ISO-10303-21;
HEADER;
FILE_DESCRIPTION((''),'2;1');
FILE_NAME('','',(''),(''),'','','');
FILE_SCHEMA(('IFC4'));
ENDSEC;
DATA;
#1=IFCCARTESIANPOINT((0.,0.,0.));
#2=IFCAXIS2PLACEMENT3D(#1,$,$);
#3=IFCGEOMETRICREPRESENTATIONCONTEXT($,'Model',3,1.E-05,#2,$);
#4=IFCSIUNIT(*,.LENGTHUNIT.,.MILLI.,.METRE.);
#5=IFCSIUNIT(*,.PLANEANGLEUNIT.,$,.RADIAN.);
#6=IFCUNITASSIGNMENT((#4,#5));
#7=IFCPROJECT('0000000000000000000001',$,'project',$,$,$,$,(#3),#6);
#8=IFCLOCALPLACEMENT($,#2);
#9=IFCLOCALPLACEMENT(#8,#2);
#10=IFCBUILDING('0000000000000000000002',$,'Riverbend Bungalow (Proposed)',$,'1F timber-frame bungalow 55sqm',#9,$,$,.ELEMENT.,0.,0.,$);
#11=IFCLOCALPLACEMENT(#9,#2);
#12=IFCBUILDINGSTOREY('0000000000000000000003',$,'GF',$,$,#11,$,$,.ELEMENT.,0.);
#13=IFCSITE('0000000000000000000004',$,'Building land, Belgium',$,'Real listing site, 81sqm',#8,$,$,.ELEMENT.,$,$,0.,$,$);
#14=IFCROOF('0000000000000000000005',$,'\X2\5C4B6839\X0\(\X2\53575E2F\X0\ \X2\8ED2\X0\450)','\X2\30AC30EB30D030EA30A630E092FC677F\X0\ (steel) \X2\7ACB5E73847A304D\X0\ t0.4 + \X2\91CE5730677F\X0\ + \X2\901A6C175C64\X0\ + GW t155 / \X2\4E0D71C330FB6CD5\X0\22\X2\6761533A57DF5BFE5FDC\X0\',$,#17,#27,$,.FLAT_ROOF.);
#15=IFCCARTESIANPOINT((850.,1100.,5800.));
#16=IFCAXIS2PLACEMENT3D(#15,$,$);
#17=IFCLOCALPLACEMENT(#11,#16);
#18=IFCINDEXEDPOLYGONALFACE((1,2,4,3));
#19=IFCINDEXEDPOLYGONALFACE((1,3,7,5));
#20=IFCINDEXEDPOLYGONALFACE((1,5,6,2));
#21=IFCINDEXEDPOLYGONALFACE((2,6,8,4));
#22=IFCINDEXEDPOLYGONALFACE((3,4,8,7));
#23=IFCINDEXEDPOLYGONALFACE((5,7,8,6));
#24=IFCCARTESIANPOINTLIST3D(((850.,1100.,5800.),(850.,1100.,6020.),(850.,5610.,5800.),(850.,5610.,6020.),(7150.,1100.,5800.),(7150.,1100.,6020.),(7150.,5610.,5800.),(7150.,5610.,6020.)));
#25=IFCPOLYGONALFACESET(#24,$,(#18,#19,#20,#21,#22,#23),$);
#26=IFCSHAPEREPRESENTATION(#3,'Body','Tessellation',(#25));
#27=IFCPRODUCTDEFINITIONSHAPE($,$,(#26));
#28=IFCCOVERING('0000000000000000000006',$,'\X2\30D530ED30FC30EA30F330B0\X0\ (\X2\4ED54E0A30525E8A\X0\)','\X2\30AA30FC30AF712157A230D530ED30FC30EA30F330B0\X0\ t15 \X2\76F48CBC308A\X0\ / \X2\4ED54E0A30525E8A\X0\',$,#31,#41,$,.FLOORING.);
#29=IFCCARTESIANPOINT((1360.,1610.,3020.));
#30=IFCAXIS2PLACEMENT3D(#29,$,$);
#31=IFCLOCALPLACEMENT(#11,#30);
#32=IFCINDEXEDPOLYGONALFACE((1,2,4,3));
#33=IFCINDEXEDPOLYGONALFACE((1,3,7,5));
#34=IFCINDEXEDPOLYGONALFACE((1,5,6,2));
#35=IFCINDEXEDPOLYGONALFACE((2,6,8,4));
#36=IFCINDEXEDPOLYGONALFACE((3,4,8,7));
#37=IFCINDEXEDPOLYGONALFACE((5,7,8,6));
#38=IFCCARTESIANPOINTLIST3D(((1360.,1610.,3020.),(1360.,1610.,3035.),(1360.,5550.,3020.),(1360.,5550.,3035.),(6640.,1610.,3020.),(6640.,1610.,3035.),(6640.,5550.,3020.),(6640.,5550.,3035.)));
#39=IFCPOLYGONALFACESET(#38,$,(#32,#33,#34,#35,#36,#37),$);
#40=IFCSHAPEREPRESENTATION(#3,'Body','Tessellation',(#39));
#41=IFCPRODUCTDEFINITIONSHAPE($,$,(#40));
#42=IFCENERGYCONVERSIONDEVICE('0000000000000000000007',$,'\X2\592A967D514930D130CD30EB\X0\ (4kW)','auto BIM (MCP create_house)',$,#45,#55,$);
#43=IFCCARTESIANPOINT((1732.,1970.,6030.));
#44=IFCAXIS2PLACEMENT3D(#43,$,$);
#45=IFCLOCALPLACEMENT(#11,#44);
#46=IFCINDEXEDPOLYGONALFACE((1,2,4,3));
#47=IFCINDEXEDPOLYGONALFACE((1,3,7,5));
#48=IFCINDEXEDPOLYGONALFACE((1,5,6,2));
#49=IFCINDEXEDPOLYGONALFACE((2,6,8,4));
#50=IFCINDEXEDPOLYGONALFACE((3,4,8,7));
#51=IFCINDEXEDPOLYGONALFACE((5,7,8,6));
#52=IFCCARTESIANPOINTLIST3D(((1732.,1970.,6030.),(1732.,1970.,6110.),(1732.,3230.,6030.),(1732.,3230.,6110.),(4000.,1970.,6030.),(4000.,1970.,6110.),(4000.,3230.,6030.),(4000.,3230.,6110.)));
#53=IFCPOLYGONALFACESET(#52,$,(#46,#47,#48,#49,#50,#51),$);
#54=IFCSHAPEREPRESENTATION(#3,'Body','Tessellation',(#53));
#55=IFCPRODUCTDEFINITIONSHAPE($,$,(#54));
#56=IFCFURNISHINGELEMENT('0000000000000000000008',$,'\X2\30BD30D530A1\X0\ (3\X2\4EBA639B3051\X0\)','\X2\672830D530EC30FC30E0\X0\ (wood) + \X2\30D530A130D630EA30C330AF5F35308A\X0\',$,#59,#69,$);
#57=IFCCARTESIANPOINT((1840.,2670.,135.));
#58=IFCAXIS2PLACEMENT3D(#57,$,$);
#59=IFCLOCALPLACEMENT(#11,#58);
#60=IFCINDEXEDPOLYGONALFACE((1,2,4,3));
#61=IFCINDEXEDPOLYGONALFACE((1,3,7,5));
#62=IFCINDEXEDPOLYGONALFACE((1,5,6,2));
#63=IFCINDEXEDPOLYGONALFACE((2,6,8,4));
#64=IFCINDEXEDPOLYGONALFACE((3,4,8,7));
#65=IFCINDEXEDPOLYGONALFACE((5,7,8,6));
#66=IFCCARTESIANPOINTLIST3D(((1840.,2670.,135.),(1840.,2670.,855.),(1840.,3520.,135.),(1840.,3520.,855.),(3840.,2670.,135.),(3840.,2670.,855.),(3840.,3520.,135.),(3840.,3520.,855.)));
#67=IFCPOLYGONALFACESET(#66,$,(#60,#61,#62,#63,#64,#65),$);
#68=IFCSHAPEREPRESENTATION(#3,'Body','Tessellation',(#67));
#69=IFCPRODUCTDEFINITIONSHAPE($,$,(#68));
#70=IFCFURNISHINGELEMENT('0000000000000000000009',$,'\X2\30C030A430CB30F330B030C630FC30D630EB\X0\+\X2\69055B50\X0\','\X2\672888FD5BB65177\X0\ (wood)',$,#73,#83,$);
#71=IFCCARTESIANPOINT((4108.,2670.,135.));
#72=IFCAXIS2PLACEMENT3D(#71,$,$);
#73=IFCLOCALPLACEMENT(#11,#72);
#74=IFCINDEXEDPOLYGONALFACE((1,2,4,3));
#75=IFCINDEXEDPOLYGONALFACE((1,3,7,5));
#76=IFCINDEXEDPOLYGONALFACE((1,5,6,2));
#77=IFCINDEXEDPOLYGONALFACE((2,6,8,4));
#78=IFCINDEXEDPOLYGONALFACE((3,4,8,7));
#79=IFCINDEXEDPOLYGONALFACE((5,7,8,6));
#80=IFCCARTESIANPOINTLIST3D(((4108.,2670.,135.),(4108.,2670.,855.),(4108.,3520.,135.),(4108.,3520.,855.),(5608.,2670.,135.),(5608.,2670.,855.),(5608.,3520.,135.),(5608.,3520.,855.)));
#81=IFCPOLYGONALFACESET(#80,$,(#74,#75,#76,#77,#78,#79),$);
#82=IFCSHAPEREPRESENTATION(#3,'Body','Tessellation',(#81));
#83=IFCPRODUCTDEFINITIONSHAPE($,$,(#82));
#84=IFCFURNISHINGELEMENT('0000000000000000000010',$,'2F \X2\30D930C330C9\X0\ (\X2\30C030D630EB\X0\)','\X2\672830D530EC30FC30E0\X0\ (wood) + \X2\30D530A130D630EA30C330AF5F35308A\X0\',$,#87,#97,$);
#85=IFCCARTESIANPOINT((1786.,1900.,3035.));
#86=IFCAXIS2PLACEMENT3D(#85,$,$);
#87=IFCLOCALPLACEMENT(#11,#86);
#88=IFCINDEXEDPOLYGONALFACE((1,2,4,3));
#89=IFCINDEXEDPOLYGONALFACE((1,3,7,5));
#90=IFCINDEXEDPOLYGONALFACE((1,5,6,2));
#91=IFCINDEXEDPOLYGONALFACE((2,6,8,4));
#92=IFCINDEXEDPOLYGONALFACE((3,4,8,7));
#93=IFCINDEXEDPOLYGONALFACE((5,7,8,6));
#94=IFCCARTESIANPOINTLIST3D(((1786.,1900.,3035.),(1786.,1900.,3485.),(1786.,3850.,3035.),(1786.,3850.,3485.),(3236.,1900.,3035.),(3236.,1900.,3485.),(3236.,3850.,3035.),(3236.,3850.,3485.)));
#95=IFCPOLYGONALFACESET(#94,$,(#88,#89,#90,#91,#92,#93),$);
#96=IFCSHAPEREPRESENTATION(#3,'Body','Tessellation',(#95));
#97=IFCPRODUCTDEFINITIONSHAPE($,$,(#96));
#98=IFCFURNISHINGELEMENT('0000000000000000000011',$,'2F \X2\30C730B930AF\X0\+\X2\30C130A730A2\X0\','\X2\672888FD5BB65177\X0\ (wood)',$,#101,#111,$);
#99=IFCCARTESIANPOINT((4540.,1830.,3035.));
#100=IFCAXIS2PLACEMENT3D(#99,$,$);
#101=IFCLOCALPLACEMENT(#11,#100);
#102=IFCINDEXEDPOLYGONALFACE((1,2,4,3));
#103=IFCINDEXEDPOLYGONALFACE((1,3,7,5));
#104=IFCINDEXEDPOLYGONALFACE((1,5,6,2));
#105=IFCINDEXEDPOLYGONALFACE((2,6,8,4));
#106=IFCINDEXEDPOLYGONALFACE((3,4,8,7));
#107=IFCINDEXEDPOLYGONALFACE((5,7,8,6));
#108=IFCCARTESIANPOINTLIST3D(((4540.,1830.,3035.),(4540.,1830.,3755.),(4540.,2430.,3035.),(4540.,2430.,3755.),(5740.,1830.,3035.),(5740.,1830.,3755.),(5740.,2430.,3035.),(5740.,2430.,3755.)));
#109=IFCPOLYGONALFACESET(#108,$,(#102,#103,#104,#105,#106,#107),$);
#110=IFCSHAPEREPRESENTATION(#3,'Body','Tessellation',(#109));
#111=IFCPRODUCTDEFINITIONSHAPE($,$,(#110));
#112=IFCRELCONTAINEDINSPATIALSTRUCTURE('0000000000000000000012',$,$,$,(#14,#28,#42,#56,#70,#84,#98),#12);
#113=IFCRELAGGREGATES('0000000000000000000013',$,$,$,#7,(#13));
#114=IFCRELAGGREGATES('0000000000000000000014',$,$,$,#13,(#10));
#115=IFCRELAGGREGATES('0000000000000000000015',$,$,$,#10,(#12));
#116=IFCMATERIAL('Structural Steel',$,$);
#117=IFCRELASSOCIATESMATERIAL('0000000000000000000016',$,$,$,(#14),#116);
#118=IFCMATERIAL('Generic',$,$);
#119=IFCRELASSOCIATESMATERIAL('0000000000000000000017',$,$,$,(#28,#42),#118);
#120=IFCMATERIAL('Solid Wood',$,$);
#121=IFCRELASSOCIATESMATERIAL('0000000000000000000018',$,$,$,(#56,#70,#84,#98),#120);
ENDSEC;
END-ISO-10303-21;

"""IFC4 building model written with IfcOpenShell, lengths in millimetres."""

from ifc_helpers import new_model, si_unit, frame, frame_2d, origin, place, context, project, spatial, rectangle, extrude, material, element, save


model = new_model("IFC4")

# Units and contexts
model_context = context("Model", 3, precision=1e-05, world=origin())
ifc_project = project(units=[si_unit("LENGTHUNIT", "METRE", prefix="MILLI"), si_unit("PLANEANGLEUNIT", "RADIAN")], contexts=[model_context])

# Site, building, storey
site_placement = place(None, origin())
site = spatial("IfcSite", under=ifc_project, at=site_placement, Name="Building land, Belgium", ObjectType="Real listing site, 81sqm", CompositionType="ELEMENT", RefElevation=0.0)
building_placement = place(site_placement, origin())
building = spatial("IfcBuilding", under=site, at=building_placement, Name="Riverbend Bungalow (Proposed)", ObjectType="1F timber-frame bungalow 55sqm", CompositionType="ELEMENT", ElevationOfRefHeight=0.0, ElevationOfTerrain=0.0)
storey_placement = place(building_placement, origin())
storey = spatial("IfcBuildingStorey", under=building, at=storey_placement, Name="GF", CompositionType="ELEMENT", Elevation=0.0)

# Shared definitions
ifc_material_1 = material(Name="Solid Wood")

# Shared definitions
ifc_material_2 = material(Name="Generic")

# Roof
ifc_material_3 = material(Name="Structural Steel")
for number, where, name in (
    (1, (850.0, 1100.0, 5800.0), "屋根(南帯 軒450)"),
):
    element("IfcRoof", number, at=place(storey_placement, frame(where)), inside=storey, material=ifc_material_3, Name=name, Description="ガルバリウム鋼板 (steel) 立平葺き t0.4 + 野地板 + 通気層 + GW t155 / 不燃・法22条区域対応", PredefinedType="FLAT_ROOF", context=model_context, shape_type="SweptSolid", body=[
        extrude(rectangle(XDim=6300.0, YDim=4510.0, at=frame_2d((3150.0, 2255.0))), frame((850.0, 1100.0, 5800.0)), (0.0, 0.0, 1.0), 220.0),
    ])

# Covering
covering_placement = place(storey_placement, frame((1360.0, 1610.0, 3020.0)))
element("IfcCovering", 2, at=covering_placement, inside=storey, material=ifc_material_2, Name="フローリング (仕上げ床)", Description="オーク無垢フローリング t15 直貼り / 仕上げ床", PredefinedType="FLOORING", context=model_context, shape_type="SweptSolid", body=[
    extrude(rectangle(XDim=5280.0, YDim=3940.0, at=frame_2d((2640.0, 1970.0))), frame((1360.0, 1610.0, 3020.0)), (0.0, 0.0, 1.0), 15.0),
])

# Energy conversion device
energy_conversion_device_placement = place(storey_placement, frame((1732.0, 1970.0, 6030.0)))
element("IfcEnergyConversionDevice", 3, at=energy_conversion_device_placement, inside=storey, material=ifc_material_2, Name="太陽光パネル (4kW)", Description="auto BIM (MCP create_house)", context=model_context, shape_type="SweptSolid", body=[
    extrude(rectangle(XDim=2268.0, YDim=1260.0, at=frame_2d((1134.0, 630.0))), frame((1732.0, 1970.0, 6030.0)), (0.0, 0.0, 1.0), 80.0),
])

# Furnishing elements
furnishing_1_placement = place(storey_placement, frame((1840.0, 2670.0, 135.0)))
element("IfcFurnishingElement", 4, at=furnishing_1_placement, inside=storey, material=ifc_material_1, Name="ソファ (3人掛け)", Description="木フレーム (wood) + ファブリック張り", context=model_context, shape_type="SweptSolid", body=[
    extrude(rectangle(XDim=2000.0, YDim=850.0, at=frame_2d((1000.0, 425.0))), frame((1840.0, 2670.0, 135.0)), (0.0, 0.0, 1.0), 720.0),
])
furnishing_2_placement = place(storey_placement, frame((4108.0, 2670.0, 135.0)))
element("IfcFurnishingElement", 5, at=furnishing_2_placement, inside=storey, material=ifc_material_1, Name="ダイニングテーブル+椅子", Description="木製家具 (wood)", context=model_context, shape_type="SweptSolid", body=[
    extrude(rectangle(XDim=1500.0, YDim=850.0, at=frame_2d((750.0, 425.0))), frame((4108.0, 2670.0, 135.0)), (0.0, 0.0, 1.0), 720.0),
])
furnishing_3_placement = place(storey_placement, frame((1786.0, 1900.0, 3035.0)))
element("IfcFurnishingElement", 6, at=furnishing_3_placement, inside=storey, material=ifc_material_1, Name="2F ベッド (ダブル)", Description="木フレーム (wood) + ファブリック張り", context=model_context, shape_type="SweptSolid", body=[
    extrude(rectangle(XDim=1450.0, YDim=1950.0, at=frame_2d((725.0, 975.0))), frame((1786.0, 1900.0, 3035.0)), (0.0, 0.0, 1.0), 450.0),
])
furnishing_4_placement = place(storey_placement, frame((4540.0, 1830.0, 3035.0)))
element("IfcFurnishingElement", 7, at=furnishing_4_placement, inside=storey, material=ifc_material_1, Name="2F デスク+チェア", Description="木製家具 (wood)", context=model_context, shape_type="SweptSolid", body=[
    extrude(rectangle(XDim=1200.0, YDim=600.0, at=frame_2d((600.0, 300.0))), frame((4540.0, 1830.0, 3035.0)), (0.0, 0.0, 1.0), 720.0),
])

save(model, "model.ifc")
